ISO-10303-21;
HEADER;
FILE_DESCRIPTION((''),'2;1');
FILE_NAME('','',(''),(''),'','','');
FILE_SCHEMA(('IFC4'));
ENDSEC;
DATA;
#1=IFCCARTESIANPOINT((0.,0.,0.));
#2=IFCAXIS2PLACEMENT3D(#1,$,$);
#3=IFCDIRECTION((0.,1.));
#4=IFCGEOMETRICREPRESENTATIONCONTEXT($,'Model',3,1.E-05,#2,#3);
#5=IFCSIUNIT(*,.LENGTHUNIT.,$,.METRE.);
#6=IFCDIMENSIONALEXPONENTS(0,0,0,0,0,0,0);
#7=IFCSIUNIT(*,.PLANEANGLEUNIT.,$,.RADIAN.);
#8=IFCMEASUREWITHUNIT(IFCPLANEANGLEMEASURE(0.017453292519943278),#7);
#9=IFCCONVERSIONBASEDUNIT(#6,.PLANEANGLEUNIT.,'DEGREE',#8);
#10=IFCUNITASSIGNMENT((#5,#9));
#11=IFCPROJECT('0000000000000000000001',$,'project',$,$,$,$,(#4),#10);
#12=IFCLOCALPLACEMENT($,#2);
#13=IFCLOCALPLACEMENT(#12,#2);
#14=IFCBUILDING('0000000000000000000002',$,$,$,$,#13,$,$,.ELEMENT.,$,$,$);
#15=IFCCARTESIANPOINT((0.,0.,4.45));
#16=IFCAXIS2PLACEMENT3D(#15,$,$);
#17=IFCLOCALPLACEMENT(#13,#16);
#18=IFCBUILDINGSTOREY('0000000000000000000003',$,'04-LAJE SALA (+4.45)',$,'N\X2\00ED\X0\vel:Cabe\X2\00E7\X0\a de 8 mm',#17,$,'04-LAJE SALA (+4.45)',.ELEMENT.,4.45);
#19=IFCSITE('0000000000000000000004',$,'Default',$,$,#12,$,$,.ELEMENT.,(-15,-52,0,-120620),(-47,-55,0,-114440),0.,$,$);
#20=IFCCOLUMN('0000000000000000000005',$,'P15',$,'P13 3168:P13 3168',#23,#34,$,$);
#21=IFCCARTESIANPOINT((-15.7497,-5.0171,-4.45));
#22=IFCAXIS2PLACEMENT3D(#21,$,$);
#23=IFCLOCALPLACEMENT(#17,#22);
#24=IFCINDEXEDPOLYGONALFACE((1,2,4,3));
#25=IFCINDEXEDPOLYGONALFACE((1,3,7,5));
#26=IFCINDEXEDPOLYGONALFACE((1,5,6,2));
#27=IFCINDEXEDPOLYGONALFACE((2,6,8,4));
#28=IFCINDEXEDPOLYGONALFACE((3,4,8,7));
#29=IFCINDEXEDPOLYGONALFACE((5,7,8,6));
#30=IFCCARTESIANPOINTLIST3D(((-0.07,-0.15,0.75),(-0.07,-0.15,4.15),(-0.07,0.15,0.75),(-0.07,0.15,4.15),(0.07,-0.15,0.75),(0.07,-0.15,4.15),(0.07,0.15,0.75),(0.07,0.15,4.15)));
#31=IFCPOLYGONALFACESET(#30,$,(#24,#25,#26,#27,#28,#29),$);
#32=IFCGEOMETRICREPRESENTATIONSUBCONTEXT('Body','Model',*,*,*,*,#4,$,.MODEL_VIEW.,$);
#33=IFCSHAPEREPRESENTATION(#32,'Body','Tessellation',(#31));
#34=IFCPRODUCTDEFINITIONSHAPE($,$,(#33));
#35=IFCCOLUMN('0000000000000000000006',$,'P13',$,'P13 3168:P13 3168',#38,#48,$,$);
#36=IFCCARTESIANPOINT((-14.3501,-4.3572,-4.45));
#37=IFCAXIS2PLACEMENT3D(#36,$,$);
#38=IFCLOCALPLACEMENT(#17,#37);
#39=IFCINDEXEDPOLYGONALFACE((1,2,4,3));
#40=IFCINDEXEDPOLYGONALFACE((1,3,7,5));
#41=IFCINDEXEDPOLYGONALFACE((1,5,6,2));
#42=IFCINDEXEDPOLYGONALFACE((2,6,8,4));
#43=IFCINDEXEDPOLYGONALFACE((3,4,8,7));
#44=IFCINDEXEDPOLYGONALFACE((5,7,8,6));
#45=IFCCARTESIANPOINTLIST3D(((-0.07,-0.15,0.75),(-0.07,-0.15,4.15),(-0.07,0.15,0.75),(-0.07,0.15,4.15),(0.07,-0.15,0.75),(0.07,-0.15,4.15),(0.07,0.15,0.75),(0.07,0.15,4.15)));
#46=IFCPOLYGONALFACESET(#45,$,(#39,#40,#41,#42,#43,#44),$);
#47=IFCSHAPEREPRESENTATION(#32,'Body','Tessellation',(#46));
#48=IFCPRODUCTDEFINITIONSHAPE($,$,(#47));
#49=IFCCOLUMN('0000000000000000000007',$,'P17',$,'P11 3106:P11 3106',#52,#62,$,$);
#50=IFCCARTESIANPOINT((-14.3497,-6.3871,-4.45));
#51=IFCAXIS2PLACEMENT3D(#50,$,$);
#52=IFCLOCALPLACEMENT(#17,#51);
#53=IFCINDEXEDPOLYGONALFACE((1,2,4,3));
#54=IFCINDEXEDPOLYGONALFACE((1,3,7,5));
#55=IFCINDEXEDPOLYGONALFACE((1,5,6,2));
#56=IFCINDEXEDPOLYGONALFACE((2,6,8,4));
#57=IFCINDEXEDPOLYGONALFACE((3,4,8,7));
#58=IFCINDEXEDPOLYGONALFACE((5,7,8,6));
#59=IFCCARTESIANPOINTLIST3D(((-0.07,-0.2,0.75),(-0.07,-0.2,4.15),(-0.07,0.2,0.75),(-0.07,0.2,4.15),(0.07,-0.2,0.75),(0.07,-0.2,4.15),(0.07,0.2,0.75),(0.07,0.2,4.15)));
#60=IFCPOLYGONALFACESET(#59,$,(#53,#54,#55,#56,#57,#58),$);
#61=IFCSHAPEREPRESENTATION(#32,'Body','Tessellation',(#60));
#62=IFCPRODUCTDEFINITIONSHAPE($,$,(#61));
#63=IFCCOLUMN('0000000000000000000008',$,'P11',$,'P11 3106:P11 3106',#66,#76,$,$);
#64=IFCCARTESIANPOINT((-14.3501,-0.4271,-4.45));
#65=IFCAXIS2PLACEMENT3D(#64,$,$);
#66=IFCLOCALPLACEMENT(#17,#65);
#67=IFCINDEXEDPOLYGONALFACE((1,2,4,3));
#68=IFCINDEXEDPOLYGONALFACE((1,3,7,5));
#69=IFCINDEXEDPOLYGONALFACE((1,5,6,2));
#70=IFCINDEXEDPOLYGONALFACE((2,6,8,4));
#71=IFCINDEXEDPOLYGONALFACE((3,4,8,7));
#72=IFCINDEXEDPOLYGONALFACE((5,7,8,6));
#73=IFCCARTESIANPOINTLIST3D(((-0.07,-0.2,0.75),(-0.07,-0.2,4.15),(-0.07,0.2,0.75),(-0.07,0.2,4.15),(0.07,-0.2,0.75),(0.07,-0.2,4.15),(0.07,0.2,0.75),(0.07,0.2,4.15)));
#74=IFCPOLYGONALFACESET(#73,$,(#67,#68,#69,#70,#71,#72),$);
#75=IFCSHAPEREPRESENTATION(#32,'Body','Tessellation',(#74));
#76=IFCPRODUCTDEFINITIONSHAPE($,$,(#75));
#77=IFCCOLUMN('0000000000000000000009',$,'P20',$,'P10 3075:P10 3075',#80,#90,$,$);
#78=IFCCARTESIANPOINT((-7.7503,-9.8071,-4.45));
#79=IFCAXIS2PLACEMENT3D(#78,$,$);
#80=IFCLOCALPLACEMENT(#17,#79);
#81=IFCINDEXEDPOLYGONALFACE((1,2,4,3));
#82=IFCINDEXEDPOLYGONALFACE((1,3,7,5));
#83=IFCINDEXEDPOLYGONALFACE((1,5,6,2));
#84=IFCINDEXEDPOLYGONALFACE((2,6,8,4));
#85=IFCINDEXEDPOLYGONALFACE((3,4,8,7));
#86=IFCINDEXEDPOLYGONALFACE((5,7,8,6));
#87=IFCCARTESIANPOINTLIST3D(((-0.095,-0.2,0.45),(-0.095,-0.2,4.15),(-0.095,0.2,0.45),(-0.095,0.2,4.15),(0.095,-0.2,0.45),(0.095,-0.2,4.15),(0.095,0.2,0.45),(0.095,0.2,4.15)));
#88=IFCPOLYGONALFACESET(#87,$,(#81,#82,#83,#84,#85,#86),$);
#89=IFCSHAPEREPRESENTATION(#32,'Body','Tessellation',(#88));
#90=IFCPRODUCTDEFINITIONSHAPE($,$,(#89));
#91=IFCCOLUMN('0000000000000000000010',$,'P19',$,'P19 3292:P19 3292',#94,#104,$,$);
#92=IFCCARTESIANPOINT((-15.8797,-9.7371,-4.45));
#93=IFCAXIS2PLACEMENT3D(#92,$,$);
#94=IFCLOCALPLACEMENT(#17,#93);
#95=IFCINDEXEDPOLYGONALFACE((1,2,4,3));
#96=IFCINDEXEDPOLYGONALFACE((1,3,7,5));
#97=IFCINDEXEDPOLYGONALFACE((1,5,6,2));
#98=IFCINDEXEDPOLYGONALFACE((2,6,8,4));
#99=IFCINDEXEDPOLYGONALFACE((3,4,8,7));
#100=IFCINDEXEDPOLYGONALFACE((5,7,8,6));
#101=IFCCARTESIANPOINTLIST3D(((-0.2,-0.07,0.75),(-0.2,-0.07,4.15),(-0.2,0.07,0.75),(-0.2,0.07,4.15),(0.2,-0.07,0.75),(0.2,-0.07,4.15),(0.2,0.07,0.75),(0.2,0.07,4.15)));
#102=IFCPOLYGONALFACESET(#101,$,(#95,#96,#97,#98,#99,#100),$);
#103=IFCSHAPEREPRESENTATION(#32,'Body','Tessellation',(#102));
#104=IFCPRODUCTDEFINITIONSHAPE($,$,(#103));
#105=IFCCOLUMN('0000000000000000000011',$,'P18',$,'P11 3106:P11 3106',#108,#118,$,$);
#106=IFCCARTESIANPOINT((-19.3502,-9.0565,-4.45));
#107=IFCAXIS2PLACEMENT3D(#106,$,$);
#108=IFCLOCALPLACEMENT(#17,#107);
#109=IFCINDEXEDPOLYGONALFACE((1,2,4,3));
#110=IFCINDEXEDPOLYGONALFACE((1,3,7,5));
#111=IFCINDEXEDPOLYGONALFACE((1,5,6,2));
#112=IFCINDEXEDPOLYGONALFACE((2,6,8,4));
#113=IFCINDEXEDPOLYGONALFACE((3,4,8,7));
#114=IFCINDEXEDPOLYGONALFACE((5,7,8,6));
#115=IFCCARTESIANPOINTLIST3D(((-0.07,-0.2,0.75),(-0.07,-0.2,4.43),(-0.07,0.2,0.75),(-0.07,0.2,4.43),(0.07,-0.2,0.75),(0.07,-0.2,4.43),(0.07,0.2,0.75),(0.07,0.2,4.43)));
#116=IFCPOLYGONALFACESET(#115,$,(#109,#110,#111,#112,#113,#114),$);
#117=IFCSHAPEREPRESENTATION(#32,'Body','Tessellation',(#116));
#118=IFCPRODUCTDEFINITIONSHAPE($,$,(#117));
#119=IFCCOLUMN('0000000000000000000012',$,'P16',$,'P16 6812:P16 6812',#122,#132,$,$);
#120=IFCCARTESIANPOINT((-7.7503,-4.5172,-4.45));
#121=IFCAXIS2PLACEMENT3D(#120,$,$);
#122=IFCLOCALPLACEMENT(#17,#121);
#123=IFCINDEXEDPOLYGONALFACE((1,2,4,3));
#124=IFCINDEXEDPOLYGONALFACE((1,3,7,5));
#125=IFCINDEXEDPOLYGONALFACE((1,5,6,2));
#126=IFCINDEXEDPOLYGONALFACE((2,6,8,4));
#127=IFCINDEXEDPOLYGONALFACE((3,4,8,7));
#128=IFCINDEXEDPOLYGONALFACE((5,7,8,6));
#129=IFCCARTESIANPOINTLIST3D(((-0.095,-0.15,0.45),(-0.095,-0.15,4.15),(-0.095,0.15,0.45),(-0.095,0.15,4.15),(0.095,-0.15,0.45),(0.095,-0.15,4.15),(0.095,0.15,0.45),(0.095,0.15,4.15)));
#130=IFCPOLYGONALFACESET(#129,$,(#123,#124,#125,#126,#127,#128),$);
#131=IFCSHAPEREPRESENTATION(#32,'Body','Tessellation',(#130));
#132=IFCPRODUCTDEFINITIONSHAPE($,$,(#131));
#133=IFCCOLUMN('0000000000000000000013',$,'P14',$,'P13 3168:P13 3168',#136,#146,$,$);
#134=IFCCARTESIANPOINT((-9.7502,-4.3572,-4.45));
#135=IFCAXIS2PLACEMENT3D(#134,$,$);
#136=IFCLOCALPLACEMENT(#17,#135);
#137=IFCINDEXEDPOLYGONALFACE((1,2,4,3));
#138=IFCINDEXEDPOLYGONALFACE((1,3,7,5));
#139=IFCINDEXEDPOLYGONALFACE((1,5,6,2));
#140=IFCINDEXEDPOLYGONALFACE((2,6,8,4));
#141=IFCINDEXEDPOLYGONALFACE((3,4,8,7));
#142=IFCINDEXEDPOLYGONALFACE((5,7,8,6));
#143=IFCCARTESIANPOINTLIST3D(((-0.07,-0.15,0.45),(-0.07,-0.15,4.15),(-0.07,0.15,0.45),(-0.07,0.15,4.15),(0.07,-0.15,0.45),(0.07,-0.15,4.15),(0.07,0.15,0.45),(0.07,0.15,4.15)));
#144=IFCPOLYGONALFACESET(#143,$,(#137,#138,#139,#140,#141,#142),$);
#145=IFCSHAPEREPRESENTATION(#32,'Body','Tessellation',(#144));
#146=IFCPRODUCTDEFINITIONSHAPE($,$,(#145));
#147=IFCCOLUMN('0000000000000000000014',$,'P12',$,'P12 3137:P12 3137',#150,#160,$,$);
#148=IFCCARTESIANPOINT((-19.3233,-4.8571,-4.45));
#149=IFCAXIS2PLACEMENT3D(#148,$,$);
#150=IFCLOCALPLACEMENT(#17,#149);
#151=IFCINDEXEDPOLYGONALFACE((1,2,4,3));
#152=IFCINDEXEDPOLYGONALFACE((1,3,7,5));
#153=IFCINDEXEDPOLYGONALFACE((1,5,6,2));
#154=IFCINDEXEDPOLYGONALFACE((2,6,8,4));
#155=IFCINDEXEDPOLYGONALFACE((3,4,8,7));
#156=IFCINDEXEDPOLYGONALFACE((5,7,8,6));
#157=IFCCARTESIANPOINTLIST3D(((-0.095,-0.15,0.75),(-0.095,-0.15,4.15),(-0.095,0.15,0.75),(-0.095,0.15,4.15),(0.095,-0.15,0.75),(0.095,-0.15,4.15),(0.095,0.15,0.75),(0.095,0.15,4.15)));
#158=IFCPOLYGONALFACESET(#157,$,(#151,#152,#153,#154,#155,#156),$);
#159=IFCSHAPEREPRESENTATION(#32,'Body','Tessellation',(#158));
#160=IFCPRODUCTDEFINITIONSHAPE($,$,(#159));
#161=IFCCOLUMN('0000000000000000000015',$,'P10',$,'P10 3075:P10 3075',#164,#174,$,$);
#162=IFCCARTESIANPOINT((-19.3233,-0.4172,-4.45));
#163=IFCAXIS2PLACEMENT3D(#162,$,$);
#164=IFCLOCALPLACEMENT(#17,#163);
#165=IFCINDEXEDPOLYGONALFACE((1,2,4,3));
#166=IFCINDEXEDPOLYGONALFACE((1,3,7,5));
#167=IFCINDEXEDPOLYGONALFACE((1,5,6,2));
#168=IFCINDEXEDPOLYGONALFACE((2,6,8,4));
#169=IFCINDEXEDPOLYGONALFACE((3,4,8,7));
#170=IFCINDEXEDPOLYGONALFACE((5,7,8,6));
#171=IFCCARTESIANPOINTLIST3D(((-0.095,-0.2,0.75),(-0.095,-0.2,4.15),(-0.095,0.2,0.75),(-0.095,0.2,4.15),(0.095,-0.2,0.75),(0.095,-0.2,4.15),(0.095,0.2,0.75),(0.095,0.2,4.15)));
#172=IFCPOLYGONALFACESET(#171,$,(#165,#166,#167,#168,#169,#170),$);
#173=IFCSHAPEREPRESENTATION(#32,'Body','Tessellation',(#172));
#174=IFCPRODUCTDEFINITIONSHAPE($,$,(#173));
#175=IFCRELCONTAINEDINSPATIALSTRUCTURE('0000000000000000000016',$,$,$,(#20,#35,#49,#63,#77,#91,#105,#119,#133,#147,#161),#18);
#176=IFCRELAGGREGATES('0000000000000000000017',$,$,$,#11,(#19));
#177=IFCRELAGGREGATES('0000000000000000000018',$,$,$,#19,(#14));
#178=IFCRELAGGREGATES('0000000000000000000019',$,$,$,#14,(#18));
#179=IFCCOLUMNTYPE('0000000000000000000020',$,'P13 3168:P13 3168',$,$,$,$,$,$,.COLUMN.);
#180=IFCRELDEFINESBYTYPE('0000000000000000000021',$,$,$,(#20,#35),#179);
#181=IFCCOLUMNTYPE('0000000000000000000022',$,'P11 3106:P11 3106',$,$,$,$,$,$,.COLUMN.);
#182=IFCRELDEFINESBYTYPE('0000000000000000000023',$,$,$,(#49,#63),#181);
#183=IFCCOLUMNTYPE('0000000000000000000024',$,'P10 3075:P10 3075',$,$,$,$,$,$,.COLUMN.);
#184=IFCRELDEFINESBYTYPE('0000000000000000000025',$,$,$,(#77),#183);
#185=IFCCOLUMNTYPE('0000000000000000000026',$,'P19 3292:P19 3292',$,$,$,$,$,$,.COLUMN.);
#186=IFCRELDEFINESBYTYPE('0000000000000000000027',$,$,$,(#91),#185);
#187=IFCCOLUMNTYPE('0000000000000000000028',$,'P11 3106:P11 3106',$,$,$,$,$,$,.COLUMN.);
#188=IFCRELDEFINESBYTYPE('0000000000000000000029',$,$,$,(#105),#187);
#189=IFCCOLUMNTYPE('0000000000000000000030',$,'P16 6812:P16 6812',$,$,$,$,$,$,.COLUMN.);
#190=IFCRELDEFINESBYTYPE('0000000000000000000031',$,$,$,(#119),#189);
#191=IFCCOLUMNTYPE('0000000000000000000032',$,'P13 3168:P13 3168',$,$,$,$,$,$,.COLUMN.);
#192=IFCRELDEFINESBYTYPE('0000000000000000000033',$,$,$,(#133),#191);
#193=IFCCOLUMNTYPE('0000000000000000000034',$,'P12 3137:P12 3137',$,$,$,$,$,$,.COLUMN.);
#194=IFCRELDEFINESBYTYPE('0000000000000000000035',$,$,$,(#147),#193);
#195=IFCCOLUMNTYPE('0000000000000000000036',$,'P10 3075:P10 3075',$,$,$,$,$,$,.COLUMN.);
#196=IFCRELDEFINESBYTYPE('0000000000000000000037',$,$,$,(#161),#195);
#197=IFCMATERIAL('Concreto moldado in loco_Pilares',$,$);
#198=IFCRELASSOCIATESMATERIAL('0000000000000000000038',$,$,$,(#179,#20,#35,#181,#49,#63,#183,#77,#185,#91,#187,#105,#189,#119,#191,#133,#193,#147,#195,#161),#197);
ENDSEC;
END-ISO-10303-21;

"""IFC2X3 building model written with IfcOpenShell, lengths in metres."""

from ifc_helpers import new_model, entity, si_unit, converted_unit, direction, frame, origin, origin_2d_with_axis, place, context, subcontext, project, spatial, rectangle, extrude, source, transform, mapped, material, type_object, type_shapes, element, save


model = new_model("IFC2X3")

# Units and contexts
model_context = context("Model", 3, precision=1e-05, world=origin(), true_north=direction((0.0, 1.0)))
body_context = subcontext(model_context, "Body", "Model", "MODEL_VIEW")
ifc_project = project(units=[si_unit("LENGTHUNIT", "METRE"), converted_unit("PLANEANGLEUNIT", "DEGREE", entity("IfcPlaneAngleMeasure", 0.017453292519943278), si_unit("PLANEANGLEUNIT", "RADIAN"), dimensions=[0, 0, 0, 0, 0, 0, 0])], contexts=[model_context])

# Site, building, storey
site_placement = place(None, origin())
site = spatial("IfcSite", under=ifc_project, at=site_placement, Name="Default", CompositionType="ELEMENT", RefLatitude=(-15, -52, 0, -120620), RefLongitude=(-47, -55, 0, -114440), RefElevation=0.0)
building_placement = place(site_placement, origin())
building = spatial("IfcBuilding", under=site, at=building_placement, CompositionType="ELEMENT")
storey_placement = place(building_placement, frame((0.0, 0.0, 4.45)))
storey = spatial("IfcBuildingStorey", under=building, at=storey_placement, Name="04-LAJE SALA (+4.45)", ObjectType="Nível:Cabeça de 8 mm", LongName="04-LAJE SALA (+4.45)", CompositionType="ELEMENT", Elevation=4.45)

# Columns
ifc_material_1 = material(Name="Concreto moldado in loco_Pilares")
column_type_1 = type_object("IfcColumnType", Name="P13 3168:P13 3168", PredefinedType="COLUMN", material=ifc_material_1)
shared_shape_1 = source(origin(), body_context, "Body", "SweptSolid", [
    extrude(rectangle(XDim=0.3, YDim=0.14, at=origin_2d_with_axis()), frame((0.0, 0.0, 0.75), z_axis=(0.0, 0.0, 1.0), x_axis=(0.0, -1.0, 0.0)), (0.0, 0.0, 1.0), 3.4),
])
type_shapes(column_type_1, [shared_shape_1])
for number, where, name in (
    (1, (-15.7497, -5.0171, -4.45), "P15"),
    (2, (-14.3501, -4.3572, -4.45), "P13"),
):
    element("IfcColumn", number, at=place(storey_placement, frame(where)), inside=storey, type_object=column_type_1, material=ifc_material_1, Name=name, ObjectType="P13 3168:P13 3168", context=body_context, shape_type="MappedRepresentation", body=[
        mapped(shared_shape_1, transform((0.0, 0.0, 0.0), scale=1.0)),
    ])
column_type_2 = type_object("IfcColumnType", Name="P11 3106:P11 3106", PredefinedType="COLUMN", material=ifc_material_1)
shared_shape_2 = source(origin(), body_context, "Body", "SweptSolid", [
    extrude(rectangle(XDim=0.4, YDim=0.14, at=origin_2d_with_axis()), frame((0.0, 0.0, 0.75), z_axis=(0.0, 0.0, 1.0), x_axis=(0.0, -1.0, 0.0)), (0.0, 0.0, 1.0), 3.4),
])
type_shapes(column_type_2, [shared_shape_2])
for number, where, name in (
    (3, (-14.3497, -6.3871, -4.45), "P17"),
    (4, (-14.3501, -0.4271, -4.45), "P11"),
):
    element("IfcColumn", number, at=place(storey_placement, frame(where)), inside=storey, type_object=column_type_2, material=ifc_material_1, Name=name, ObjectType="P11 3106:P11 3106", context=body_context, shape_type="MappedRepresentation", body=[
        mapped(shared_shape_2, transform((0.0, 0.0, 0.0), scale=1.0)),
    ])
column_type_3 = type_object("IfcColumnType", Name="P10 3075:P10 3075", PredefinedType="COLUMN", material=ifc_material_1)
shared_shape_3 = source(origin(), body_context, "Body", "SweptSolid", [
    extrude(rectangle(XDim=0.4, YDim=0.19, at=origin_2d_with_axis()), frame((0.0, 0.0, 0.45), z_axis=(0.0, 0.0, 1.0), x_axis=(0.0, -1.0, 0.0)), (0.0, 0.0, 1.0), 3.7),
])
type_shapes(column_type_3, [shared_shape_3])
column_1_placement = place(storey_placement, frame((-7.7503, -9.8071, -4.45)))
element("IfcColumn", 5, at=column_1_placement, inside=storey, type_object=column_type_3, material=ifc_material_1, Name="P20", ObjectType="P10 3075:P10 3075", context=body_context, shape_type="MappedRepresentation", body=[
    mapped(shared_shape_3, transform((0.0, 0.0, 0.0), scale=1.0)),
])
column_type_4 = type_object("IfcColumnType", Name="P19 3292:P19 3292", PredefinedType="COLUMN", material=ifc_material_1)
shared_shape_4 = source(origin(), body_context, "Body", "SweptSolid", [
    extrude(rectangle(XDim=0.4, YDim=0.14, at=origin_2d_with_axis()), frame((0.0, 0.0, 0.75)), (0.0, 0.0, 1.0), 3.4),
])
type_shapes(column_type_4, [shared_shape_4])
column_2_placement = place(storey_placement, frame((-15.8797, -9.7371, -4.45)))
element("IfcColumn", 6, at=column_2_placement, inside=storey, type_object=column_type_4, material=ifc_material_1, Name="P19", ObjectType="P19 3292:P19 3292", context=body_context, shape_type="MappedRepresentation", body=[
    mapped(shared_shape_4, transform((0.0, 0.0, 0.0), scale=1.0)),
])
column_type_5 = type_object("IfcColumnType", Name="P11 3106:P11 3106", PredefinedType="COLUMN", material=ifc_material_1)
shared_shape_5 = source(origin(), body_context, "Body", "SweptSolid", [
    extrude(rectangle(XDim=0.4, YDim=0.14, at=origin_2d_with_axis()), frame((0.0, 0.0, 0.75), z_axis=(0.0, 0.0, 1.0), x_axis=(0.0, -1.0, 0.0)), (0.0, 0.0, 1.0), 3.68),
])
type_shapes(column_type_5, [shared_shape_5])
column_3_placement = place(storey_placement, frame((-19.3502, -9.0565, -4.45)))
element("IfcColumn", 7, at=column_3_placement, inside=storey, type_object=column_type_5, material=ifc_material_1, Name="P18", ObjectType="P11 3106:P11 3106", context=body_context, shape_type="MappedRepresentation", body=[
    mapped(shared_shape_5, transform((0.0, 0.0, 0.0), scale=1.0)),
])
column_type_6 = type_object("IfcColumnType", Name="P16 6812:P16 6812", PredefinedType="COLUMN", material=ifc_material_1)
shared_shape_6 = source(origin(), body_context, "Body", "SweptSolid", [
    extrude(rectangle(XDim=0.3, YDim=0.19, at=origin_2d_with_axis()), frame((0.0, 0.0, 0.45), z_axis=(0.0, 0.0, 1.0), x_axis=(0.0, 1.0, 0.0)), (0.0, 0.0, 1.0), 3.7),
])
type_shapes(column_type_6, [shared_shape_6])
column_4_placement = place(storey_placement, frame((-7.7503, -4.5172, -4.45)))
element("IfcColumn", 8, at=column_4_placement, inside=storey, type_object=column_type_6, material=ifc_material_1, Name="P16", ObjectType="P16 6812:P16 6812", context=body_context, shape_type="MappedRepresentation", body=[
    mapped(shared_shape_6, transform((0.0, 0.0, 0.0), scale=1.0)),
])
column_type_7 = type_object("IfcColumnType", Name="P13 3168:P13 3168", PredefinedType="COLUMN", material=ifc_material_1)
shared_shape_7 = source(origin(), body_context, "Body", "SweptSolid", [
    extrude(rectangle(XDim=0.3, YDim=0.14, at=origin_2d_with_axis()), frame((0.0, 0.0, 0.45), z_axis=(0.0, 0.0, 1.0), x_axis=(0.0, -1.0, 0.0)), (0.0, 0.0, 1.0), 3.7),
])
type_shapes(column_type_7, [shared_shape_7])
column_5_placement = place(storey_placement, frame((-9.7502, -4.3572, -4.45)))
element("IfcColumn", 9, at=column_5_placement, inside=storey, type_object=column_type_7, material=ifc_material_1, Name="P14", ObjectType="P13 3168:P13 3168", context=body_context, shape_type="MappedRepresentation", body=[
    mapped(shared_shape_7, transform((0.0, 0.0, 0.0), scale=1.0)),
])
column_type_8 = type_object("IfcColumnType", Name="P12 3137:P12 3137", PredefinedType="COLUMN", material=ifc_material_1)
shared_shape_8 = source(origin(), body_context, "Body", "SweptSolid", [
    extrude(rectangle(XDim=0.3, YDim=0.19, at=origin_2d_with_axis()), frame((0.0, 0.0, 0.75), z_axis=(0.0, 0.0, 1.0), x_axis=(0.0, -1.0, 0.0)), (0.0, 0.0, 1.0), 3.4),
])
type_shapes(column_type_8, [shared_shape_8])
column_6_placement = place(storey_placement, frame((-19.3233, -4.8571, -4.45)))
element("IfcColumn", 10, at=column_6_placement, inside=storey, type_object=column_type_8, material=ifc_material_1, Name="P12", ObjectType="P12 3137:P12 3137", context=body_context, shape_type="MappedRepresentation", body=[
    mapped(shared_shape_8, transform((0.0, 0.0, 0.0), scale=1.0)),
])
column_type_9 = type_object("IfcColumnType", Name="P10 3075:P10 3075", PredefinedType="COLUMN", material=ifc_material_1)
shared_shape_9 = source(origin(), body_context, "Body", "SweptSolid", [
    extrude(rectangle(XDim=0.4, YDim=0.19, at=origin_2d_with_axis()), frame((0.0, 0.0, 0.75), z_axis=(0.0, 0.0, 1.0), x_axis=(0.0, -1.0, 0.0)), (0.0, 0.0, 1.0), 3.4),
])
type_shapes(column_type_9, [shared_shape_9])
column_7_placement = place(storey_placement, frame((-19.3233, -0.4172, -4.45)))
element("IfcColumn", 11, at=column_7_placement, inside=storey, type_object=column_type_9, material=ifc_material_1, Name="P10", ObjectType="P10 3075:P10 3075", context=body_context, shape_type="MappedRepresentation", body=[
    mapped(shared_shape_9, transform((0.0, 0.0, 0.0), scale=1.0)),
])

save(model, "model.ifc")
